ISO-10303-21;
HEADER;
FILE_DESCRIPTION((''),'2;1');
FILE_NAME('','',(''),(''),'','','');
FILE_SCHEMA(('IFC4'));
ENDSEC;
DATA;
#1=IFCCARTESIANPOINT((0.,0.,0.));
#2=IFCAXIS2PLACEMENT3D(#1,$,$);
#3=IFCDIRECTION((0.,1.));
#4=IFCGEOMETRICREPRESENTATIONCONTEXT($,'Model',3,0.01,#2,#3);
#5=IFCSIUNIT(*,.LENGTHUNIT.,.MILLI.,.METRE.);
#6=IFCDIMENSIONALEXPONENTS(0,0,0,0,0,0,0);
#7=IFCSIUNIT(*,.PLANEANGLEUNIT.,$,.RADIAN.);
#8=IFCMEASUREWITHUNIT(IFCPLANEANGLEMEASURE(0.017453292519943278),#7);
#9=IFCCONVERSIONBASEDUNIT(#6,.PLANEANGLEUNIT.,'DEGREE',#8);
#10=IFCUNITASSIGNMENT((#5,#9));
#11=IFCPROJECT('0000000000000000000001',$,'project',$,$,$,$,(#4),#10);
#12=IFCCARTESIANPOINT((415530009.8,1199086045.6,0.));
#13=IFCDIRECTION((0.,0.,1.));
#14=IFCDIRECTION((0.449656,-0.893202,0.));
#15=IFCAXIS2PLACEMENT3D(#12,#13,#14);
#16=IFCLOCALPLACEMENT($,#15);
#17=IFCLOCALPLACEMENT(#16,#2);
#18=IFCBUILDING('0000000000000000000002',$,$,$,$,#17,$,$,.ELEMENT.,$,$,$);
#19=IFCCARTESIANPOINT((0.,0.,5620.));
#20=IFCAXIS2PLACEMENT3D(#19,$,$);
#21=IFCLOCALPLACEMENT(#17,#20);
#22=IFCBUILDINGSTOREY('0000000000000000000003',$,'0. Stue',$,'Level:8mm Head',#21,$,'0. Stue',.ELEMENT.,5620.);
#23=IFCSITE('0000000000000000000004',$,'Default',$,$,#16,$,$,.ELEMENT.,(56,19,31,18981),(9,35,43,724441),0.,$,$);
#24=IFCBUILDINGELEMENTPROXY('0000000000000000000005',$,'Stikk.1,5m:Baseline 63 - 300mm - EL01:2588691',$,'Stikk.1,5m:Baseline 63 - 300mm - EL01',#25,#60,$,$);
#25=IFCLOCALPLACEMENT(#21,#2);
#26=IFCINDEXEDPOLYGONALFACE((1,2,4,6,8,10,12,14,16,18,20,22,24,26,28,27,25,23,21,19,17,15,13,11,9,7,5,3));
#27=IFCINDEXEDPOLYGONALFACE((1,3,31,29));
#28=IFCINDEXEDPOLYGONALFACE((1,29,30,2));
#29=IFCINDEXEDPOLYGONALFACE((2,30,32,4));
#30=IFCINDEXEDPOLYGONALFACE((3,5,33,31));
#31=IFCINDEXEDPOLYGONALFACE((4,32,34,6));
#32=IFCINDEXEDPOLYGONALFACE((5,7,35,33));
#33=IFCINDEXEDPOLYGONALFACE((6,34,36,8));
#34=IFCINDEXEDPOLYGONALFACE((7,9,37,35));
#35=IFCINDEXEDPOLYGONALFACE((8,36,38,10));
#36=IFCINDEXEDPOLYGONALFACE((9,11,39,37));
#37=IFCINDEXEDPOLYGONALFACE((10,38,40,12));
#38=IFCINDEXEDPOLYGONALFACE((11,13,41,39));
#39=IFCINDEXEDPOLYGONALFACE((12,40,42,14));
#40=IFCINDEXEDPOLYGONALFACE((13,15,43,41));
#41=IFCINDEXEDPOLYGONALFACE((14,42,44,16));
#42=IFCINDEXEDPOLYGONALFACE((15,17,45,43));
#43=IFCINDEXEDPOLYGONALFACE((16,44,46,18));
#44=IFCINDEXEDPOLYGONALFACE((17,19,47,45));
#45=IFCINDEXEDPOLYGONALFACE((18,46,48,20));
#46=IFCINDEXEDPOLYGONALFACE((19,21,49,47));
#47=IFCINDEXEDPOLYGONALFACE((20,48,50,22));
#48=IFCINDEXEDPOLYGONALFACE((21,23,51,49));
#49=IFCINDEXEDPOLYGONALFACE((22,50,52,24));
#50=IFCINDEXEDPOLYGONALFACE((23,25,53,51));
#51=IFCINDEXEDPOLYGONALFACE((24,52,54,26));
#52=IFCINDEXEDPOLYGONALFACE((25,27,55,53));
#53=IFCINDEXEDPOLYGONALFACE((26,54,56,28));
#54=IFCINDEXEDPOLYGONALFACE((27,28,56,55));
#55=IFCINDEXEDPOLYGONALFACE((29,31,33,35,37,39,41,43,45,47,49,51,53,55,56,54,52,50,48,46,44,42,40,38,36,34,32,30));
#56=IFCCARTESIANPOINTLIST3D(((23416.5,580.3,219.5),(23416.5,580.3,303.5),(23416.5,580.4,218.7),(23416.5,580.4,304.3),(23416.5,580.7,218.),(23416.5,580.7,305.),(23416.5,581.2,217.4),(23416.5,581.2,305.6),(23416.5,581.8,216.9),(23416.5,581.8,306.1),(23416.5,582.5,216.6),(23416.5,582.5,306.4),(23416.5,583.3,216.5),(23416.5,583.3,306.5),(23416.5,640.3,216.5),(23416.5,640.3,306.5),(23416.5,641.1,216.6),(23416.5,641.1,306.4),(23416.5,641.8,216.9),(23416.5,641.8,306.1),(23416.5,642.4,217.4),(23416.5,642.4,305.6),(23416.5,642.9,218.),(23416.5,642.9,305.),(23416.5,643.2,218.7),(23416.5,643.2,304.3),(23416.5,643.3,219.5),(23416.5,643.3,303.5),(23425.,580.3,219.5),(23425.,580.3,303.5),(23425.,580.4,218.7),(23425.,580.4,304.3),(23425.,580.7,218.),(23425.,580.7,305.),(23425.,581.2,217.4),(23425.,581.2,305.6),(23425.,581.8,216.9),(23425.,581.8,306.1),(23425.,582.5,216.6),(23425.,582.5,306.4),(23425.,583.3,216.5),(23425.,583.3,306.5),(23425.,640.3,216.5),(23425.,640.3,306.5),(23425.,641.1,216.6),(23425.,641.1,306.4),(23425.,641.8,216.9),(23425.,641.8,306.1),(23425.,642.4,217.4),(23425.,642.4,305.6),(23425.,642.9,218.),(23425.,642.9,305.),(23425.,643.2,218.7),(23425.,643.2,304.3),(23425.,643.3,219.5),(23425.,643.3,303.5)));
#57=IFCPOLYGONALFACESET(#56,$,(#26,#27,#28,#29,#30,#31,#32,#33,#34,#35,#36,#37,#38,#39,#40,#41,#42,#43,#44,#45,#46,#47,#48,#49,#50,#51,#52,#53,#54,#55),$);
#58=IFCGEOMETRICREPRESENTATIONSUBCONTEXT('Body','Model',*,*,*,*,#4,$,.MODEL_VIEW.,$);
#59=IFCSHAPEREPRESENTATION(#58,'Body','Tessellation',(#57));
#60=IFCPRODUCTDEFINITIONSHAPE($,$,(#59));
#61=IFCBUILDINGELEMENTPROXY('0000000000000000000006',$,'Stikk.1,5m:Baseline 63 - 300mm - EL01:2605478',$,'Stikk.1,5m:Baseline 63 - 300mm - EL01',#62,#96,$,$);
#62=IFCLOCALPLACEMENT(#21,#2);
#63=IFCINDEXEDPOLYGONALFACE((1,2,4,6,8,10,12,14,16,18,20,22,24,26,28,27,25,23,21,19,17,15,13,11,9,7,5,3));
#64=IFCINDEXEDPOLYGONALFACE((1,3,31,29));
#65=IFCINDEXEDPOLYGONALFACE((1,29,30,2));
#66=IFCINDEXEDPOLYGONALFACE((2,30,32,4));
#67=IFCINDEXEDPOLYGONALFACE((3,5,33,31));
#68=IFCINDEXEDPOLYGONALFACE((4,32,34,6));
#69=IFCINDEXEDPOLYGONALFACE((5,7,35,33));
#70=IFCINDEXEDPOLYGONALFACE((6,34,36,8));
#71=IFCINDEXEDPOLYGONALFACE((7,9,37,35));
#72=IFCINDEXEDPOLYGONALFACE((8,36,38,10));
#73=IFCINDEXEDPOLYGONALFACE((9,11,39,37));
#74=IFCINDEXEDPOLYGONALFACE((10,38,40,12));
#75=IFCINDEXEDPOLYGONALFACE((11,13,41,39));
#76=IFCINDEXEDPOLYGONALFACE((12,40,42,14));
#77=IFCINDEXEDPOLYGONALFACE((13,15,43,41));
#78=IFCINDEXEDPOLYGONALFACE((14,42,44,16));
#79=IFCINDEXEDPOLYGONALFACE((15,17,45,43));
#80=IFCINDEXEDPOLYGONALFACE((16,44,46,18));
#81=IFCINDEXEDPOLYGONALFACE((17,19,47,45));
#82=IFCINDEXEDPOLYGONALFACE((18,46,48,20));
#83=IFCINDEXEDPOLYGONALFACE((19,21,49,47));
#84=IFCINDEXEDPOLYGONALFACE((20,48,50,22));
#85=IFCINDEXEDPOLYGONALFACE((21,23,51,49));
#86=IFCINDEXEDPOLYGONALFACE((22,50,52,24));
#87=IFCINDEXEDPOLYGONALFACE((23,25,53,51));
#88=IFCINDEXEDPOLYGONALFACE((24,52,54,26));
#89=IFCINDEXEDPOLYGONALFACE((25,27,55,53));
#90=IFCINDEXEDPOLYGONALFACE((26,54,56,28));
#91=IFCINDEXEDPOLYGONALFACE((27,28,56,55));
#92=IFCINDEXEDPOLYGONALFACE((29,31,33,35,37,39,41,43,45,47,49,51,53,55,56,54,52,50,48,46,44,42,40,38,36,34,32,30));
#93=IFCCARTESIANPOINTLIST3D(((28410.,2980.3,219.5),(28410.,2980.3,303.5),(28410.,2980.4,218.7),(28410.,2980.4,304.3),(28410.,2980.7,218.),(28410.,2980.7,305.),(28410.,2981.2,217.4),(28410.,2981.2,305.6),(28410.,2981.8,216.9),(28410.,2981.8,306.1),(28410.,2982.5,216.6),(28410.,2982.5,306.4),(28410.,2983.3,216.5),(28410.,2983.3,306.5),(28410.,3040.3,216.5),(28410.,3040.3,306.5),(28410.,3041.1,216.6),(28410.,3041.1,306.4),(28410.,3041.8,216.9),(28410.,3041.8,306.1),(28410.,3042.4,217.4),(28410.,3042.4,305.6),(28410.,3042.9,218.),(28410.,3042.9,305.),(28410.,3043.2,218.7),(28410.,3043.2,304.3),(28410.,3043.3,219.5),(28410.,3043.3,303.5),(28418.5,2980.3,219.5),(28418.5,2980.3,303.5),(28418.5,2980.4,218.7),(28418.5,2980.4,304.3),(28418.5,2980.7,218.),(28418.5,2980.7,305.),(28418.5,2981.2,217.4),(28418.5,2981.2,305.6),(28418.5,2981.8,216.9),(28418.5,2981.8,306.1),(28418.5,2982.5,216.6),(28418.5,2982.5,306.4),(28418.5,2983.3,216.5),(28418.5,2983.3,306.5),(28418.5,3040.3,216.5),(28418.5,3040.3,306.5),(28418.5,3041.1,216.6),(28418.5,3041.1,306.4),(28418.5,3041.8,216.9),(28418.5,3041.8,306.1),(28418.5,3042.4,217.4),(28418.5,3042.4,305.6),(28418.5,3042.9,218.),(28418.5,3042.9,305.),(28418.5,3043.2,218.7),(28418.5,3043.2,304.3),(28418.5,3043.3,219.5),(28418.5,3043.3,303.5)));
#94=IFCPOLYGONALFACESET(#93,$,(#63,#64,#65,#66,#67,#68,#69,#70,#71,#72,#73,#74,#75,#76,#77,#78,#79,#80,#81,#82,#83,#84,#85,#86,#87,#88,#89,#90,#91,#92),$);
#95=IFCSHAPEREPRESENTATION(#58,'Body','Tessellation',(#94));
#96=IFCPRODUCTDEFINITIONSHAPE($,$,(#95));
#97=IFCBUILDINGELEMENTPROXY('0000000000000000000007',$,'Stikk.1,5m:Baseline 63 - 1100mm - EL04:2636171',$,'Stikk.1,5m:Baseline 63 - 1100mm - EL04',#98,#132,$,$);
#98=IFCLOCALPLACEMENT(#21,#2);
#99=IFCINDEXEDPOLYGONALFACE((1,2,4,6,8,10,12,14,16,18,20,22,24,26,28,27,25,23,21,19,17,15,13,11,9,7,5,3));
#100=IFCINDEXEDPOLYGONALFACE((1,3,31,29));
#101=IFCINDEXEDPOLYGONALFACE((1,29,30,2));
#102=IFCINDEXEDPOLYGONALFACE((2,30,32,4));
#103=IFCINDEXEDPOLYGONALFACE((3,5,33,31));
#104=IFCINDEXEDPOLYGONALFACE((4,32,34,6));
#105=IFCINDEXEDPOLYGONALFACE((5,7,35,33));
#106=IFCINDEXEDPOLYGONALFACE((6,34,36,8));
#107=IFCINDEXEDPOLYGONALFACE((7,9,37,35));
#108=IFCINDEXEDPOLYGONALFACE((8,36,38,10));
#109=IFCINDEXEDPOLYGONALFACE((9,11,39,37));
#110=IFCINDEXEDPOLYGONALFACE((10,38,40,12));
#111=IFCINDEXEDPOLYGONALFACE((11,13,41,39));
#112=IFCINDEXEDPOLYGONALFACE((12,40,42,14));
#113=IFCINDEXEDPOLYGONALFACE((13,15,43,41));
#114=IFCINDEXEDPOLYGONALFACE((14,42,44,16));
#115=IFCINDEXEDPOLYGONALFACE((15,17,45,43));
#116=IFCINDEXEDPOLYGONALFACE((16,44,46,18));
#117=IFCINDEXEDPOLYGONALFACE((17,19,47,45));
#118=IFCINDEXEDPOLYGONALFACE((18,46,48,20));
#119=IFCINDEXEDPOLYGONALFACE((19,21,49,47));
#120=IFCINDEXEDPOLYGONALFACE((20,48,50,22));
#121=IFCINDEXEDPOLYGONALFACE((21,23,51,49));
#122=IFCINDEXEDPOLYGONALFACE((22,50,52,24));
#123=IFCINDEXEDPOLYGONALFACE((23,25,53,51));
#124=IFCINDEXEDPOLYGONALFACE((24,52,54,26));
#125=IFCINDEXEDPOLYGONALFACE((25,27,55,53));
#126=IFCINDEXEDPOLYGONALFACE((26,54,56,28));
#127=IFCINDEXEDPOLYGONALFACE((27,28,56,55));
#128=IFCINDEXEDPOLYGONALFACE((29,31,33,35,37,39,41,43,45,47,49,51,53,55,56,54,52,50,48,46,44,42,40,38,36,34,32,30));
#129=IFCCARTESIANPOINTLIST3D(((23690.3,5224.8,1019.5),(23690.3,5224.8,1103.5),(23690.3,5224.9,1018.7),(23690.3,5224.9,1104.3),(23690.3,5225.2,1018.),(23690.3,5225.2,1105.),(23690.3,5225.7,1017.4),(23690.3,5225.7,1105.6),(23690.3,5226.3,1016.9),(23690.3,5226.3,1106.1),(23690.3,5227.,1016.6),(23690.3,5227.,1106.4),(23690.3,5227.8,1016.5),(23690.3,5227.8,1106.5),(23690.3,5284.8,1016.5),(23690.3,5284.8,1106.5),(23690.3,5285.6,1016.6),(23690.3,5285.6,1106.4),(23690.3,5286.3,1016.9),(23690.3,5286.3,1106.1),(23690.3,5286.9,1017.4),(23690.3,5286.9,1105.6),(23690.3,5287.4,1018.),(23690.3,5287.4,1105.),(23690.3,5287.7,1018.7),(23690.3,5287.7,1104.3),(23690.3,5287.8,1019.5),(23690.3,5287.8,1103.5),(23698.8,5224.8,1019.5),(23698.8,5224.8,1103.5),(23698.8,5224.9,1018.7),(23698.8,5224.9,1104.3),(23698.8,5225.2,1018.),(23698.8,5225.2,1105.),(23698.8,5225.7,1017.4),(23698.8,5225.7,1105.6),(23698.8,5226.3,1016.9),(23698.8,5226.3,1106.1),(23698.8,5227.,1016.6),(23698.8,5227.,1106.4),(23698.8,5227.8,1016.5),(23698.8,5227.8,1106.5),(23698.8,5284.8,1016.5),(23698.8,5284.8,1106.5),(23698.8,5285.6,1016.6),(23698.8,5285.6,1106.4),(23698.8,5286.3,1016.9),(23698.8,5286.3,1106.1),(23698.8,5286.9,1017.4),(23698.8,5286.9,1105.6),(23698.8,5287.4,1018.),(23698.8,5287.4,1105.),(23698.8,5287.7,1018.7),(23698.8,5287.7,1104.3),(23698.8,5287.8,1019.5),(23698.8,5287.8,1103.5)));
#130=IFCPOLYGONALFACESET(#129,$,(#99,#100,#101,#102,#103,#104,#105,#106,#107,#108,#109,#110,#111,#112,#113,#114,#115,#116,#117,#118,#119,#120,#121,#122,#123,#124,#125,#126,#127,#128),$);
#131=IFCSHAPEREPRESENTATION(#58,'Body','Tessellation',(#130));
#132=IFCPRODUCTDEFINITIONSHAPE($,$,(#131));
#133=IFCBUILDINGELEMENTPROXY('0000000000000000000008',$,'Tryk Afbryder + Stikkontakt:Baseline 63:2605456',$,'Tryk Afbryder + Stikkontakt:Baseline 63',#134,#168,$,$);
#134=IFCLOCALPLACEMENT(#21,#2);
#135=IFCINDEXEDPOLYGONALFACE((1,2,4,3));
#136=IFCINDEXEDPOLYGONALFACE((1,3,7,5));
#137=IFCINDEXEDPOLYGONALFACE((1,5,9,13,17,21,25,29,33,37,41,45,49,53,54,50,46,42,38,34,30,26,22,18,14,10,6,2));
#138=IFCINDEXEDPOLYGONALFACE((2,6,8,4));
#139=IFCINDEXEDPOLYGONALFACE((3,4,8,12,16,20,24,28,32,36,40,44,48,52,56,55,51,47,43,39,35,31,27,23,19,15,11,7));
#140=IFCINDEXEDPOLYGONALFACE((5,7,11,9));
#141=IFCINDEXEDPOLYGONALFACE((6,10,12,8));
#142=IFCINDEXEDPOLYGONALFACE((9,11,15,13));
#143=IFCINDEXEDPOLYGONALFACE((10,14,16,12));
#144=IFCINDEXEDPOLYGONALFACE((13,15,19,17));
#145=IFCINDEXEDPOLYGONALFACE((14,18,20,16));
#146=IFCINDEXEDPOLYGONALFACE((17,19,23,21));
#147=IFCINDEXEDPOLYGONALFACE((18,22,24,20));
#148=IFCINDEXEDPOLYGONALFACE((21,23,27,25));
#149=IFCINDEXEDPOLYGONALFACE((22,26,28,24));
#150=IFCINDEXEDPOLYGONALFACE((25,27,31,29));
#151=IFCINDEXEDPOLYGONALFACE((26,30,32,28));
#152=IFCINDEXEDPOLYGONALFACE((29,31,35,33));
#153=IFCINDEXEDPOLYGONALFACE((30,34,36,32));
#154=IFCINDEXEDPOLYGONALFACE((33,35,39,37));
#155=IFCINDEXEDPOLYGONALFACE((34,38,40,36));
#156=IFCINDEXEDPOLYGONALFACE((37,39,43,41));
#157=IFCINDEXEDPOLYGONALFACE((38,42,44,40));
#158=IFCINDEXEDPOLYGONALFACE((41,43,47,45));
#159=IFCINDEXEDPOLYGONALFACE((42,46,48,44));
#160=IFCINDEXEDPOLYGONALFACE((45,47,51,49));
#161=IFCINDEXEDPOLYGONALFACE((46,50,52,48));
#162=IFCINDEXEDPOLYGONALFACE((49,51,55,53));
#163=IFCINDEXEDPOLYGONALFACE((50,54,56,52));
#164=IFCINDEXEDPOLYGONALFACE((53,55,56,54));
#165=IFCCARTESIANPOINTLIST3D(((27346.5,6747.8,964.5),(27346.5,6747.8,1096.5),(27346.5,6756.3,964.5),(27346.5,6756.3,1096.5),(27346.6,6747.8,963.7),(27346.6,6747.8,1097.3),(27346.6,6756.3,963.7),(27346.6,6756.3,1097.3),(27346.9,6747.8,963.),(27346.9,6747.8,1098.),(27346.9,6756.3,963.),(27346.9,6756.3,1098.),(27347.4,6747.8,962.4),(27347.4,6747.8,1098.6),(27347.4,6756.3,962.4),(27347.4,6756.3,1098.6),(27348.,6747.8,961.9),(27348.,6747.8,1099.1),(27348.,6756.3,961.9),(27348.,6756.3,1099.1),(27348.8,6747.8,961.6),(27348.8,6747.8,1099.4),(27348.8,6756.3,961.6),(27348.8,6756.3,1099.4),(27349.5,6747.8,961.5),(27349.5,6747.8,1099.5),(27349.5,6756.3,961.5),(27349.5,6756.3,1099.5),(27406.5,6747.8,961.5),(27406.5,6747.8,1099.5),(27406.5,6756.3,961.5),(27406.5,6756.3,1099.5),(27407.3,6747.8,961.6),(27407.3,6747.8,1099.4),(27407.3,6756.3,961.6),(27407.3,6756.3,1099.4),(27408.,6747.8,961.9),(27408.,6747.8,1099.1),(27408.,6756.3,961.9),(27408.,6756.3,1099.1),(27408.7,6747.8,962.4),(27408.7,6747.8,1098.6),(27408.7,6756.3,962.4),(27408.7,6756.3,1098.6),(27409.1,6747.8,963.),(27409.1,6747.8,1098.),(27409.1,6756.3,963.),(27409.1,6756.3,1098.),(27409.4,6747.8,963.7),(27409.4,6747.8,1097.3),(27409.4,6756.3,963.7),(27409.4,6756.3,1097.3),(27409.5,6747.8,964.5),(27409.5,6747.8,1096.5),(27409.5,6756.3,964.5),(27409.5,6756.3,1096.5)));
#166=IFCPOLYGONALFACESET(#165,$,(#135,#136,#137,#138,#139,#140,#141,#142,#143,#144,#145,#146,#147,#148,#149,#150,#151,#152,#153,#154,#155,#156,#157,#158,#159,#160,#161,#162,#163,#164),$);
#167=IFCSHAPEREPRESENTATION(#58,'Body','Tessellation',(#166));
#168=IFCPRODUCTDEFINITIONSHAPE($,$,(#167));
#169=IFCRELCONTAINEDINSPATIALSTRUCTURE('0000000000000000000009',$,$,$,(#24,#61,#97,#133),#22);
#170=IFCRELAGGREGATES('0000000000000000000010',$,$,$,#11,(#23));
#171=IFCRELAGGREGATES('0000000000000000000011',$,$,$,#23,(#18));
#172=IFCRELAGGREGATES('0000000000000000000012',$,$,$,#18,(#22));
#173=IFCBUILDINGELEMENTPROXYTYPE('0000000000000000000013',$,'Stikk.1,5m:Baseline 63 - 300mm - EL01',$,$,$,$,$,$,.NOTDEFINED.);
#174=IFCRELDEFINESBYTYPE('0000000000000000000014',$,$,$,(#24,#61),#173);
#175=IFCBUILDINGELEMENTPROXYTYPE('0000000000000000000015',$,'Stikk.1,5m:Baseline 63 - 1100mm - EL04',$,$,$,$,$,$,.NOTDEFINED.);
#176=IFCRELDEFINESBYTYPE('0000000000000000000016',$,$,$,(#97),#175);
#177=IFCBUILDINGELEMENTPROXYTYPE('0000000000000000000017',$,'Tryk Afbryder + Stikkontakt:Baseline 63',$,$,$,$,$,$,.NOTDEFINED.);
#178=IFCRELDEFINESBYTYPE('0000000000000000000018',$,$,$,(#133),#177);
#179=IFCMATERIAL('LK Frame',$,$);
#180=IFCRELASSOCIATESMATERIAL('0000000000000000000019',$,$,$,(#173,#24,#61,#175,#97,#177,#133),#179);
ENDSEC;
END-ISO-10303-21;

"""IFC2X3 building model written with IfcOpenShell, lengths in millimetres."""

from ifc_helpers import new_model, entity, si_unit, converted_unit, direction, frame, frame_2d, origin, place, context, subcontext, project, spatial, polyline, circle_curve, parameter, trimmed, segment, composite_curve, outline, extrude, source, transform, mapped, material, type_object, type_shapes, element, save


model = new_model("IFC2X3")

# Units and contexts
model_context = context("Model", 3, precision=0.01, world=origin(), true_north=direction((0.0, 1.0)))
body_context = subcontext(model_context, "Body", "Model", "MODEL_VIEW")
ifc_project = project(units=[si_unit("LENGTHUNIT", "METRE", prefix="MILLI"), converted_unit("PLANEANGLEUNIT", "DEGREE", entity("IfcPlaneAngleMeasure", 0.017453292519943278), si_unit("PLANEANGLEUNIT", "RADIAN"), dimensions=[0, 0, 0, 0, 0, 0, 0])], contexts=[model_context])

# Site, building, storey
site_placement = place(None, frame((415530009.8, 1199086045.6, 0.0), z_axis=(0.0, 0.0, 1.0), x_axis=(0.449656, -0.893202, 0.0)))
site = spatial("IfcSite", under=ifc_project, at=site_placement, Name="Default", CompositionType="ELEMENT", RefLatitude=(56, 19, 31, 18981), RefLongitude=(9, 35, 43, 724441), RefElevation=0.0)
building_placement = place(site_placement, origin())
building = spatial("IfcBuilding", under=site, at=building_placement, CompositionType="ELEMENT")
storey_placement = place(building_placement, frame((0.0, 0.0, 5620.0)))
storey = spatial("IfcBuildingStorey", under=building, at=storey_placement, Name="0. Stue", ObjectType="Level:8mm Head", LongName="0. Stue", CompositionType="ELEMENT", Elevation=5620.0)

# Building element proxies
ifc_material_1 = material(Name="LK Frame")
building_element_proxy_type_1 = type_object("IfcBuildingElementProxyType", Name="Stikk.1,5m:Baseline 63 - 300mm - EL01", PredefinedType="NOTDEFINED", material=ifc_material_1)
shared_shape_1 = source(origin(), body_context, "Body", "SweptSolid", [
    extrude(outline(composite_curve([segment(polyline([(-42.0, -31.5), (42.0, -31.5)]), True, "CONTINUOUS"), segment(trimmed(circle_curve(frame_2d((42.0, -28.5), x_axis=(-1.0, 0.0)), 3.0), [parameter(90.0)], [parameter(180.0)], True, "PARAMETER"), True, "CONTINUOUS"), segment(polyline([(45.0, -28.5), (45.0, 28.5)]), True, "CONTINUOUS"), segment(trimmed(circle_curve(frame_2d((42.0, 28.5), x_axis=(-1.0, 0.0)), 3.0), [parameter(180.0)], [parameter(270.0)], True, "PARAMETER"), True, "CONTINUOUS"), segment(polyline([(42.0, 31.5), (-42.0, 31.5)]), True, "CONTINUOUS"), segment(trimmed(circle_curve(frame_2d((-42.0, 28.5), x_axis=(1.0, 0.0)), 3.0), [parameter(90.0)], [parameter(180.0)], True, "PARAMETER"), True, "CONTINUOUS"), segment(polyline([(-45.0, 28.5), (-45.0, -28.5)]), True, "CONTINUOUS"), segment(trimmed(circle_curve(frame_2d((-42.0, -28.5), x_axis=(1.0, 0.0)), 3.0), [parameter(180.0)], [parameter(270.0)], True, "PARAMETER"), True, "CONTINUOUS")], self_intersect=False)), frame((0.0, -38.5, 0.0), z_axis=(0.0, 0.0, 1.0), x_axis=(0.0, 1.0, 0.0)), (0.0, 0.0, 1.0), 8.5),
])
type_shapes(building_element_proxy_type_1, [shared_shape_1])
for number, where, z_axis, x_axis, name in (
    (1, (23425.0, 611.8, 300.0), (-1.0, 0.0, 0.0), (0.0, -1.0, 0.0), "Stikk.1,5m:Baseline 63 - 300mm - EL01:2588691"),
    (2, (28410.0, 3011.8, 300.0), (1.0, 0.0, 0.0), (0.0, 1.0, 0.0), "Stikk.1,5m:Baseline 63 - 300mm - EL01:2605478"),
):
    element("IfcBuildingElementProxy", number, at=place(storey_placement, frame(where, z_axis=z_axis, x_axis=x_axis)), inside=storey, type_object=building_element_proxy_type_1, material=ifc_material_1, Name=name, ObjectType="Stikk.1,5m:Baseline 63 - 300mm - EL01", context=body_context, shape_type="MappedRepresentation", body=[
        mapped(shared_shape_1, transform((0.0, 0.0, 0.0), scale=1.0)),
    ])
building_element_proxy_type_2 = type_object("IfcBuildingElementProxyType", Name="Stikk.1,5m:Baseline 63 - 1100mm - EL04", PredefinedType="NOTDEFINED", material=ifc_material_1)
shared_shape_2 = source(origin(), body_context, "Body", "SweptSolid", [
    extrude(outline(composite_curve([segment(polyline([(-42.0, -31.5), (42.0, -31.5)]), True, "CONTINUOUS"), segment(trimmed(circle_curve(frame_2d((42.0, -28.5), x_axis=(-1.0, 0.0)), 3.0), [parameter(90.0)], [parameter(180.0)], True, "PARAMETER"), True, "CONTINUOUS"), segment(polyline([(45.0, -28.5), (45.0, 28.5)]), True, "CONTINUOUS"), segment(trimmed(circle_curve(frame_2d((42.0, 28.5), x_axis=(-1.0, 0.0)), 3.0), [parameter(180.0)], [parameter(270.0)], True, "PARAMETER"), True, "CONTINUOUS"), segment(polyline([(42.0, 31.5), (-42.0, 31.5)]), True, "CONTINUOUS"), segment(trimmed(circle_curve(frame_2d((-42.0, 28.5), x_axis=(1.0, 0.0)), 3.0), [parameter(90.0)], [parameter(180.0)], True, "PARAMETER"), True, "CONTINUOUS"), segment(polyline([(-45.0, 28.5), (-45.0, -28.5)]), True, "CONTINUOUS"), segment(trimmed(circle_curve(frame_2d((-42.0, -28.5), x_axis=(1.0, 0.0)), 3.0), [parameter(180.0)], [parameter(270.0)], True, "PARAMETER"), True, "CONTINUOUS")], self_intersect=False)), frame((0.0, -38.5, 0.0), z_axis=(0.0, 0.0, 1.0), x_axis=(0.0, 1.0, 0.0)), (0.0, 0.0, 1.0), 8.5),
])
type_shapes(building_element_proxy_type_2, [shared_shape_2])
proxy_1_placement = place(storey_placement, frame((23690.3, 5256.3, 1100.0), z_axis=(1.0, 0.0, 0.0), x_axis=(0.0, 1.0, 0.0)))
element("IfcBuildingElementProxy", 3, at=proxy_1_placement, inside=storey, type_object=building_element_proxy_type_2, material=ifc_material_1, Name="Stikk.1,5m:Baseline 63 - 1100mm - EL04:2636171", ObjectType="Stikk.1,5m:Baseline 63 - 1100mm - EL04", context=body_context, shape_type="MappedRepresentation", body=[
    mapped(shared_shape_2, transform((0.0, 0.0, 0.0), scale=1.0)),
])
building_element_proxy_type_3 = type_object("IfcBuildingElementProxyType", Name="Tryk Afbryder + Stikkontakt:Baseline 63", PredefinedType="NOTDEFINED", material=ifc_material_1)
shared_shape_3 = source(origin(), body_context, "Body", "SweptSolid", [
    extrude(outline(composite_curve([segment(polyline([(-66.0, -31.5), (66.0, -31.5)]), True, "CONTINUOUS"), segment(trimmed(circle_curve(frame_2d((66.0, -28.5), x_axis=(-1.0, 0.0)), 3.0), [parameter(90.0)], [parameter(180.0)], True, "PARAMETER"), True, "CONTINUOUS"), segment(polyline([(69.0, -28.5), (69.0, 28.5)]), True, "CONTINUOUS"), segment(trimmed(circle_curve(frame_2d((66.0, 28.5), x_axis=(-1.0, 0.0)), 3.0), [parameter(180.0)], [parameter(270.0)], True, "PARAMETER"), True, "CONTINUOUS"), segment(polyline([(66.0, 31.5), (-66.0, 31.5)]), True, "CONTINUOUS"), segment(trimmed(circle_curve(frame_2d((-66.0, 28.5), x_axis=(1.0, 0.0)), 3.0), [parameter(90.0)], [parameter(180.0)], True, "PARAMETER"), True, "CONTINUOUS"), segment(polyline([(-69.0, 28.5), (-69.0, -28.5)]), True, "CONTINUOUS"), segment(trimmed(circle_curve(frame_2d((-66.0, -28.5), x_axis=(1.0, 0.0)), 3.0), [parameter(180.0)], [parameter(270.0)], True, "PARAMETER"), True, "CONTINUOUS")], self_intersect=False)), frame((0.0, -69.5, 0.0), z_axis=(0.0, 0.0, 1.0), x_axis=(0.0, 1.0, 0.0)), (0.0, 0.0, 1.0), 8.5),
])
type_shapes(building_element_proxy_type_3, [shared_shape_3])
proxy_2_placement = place(storey_placement, frame((27378.0, 6756.3, 1100.0), z_axis=(0.0, -1.0, 0.0), x_axis=(1.0, 0.0, 0.0)))
element("IfcBuildingElementProxy", 4, at=proxy_2_placement, inside=storey, type_object=building_element_proxy_type_3, material=ifc_material_1, Name="Tryk Afbryder + Stikkontakt:Baseline 63:2605456", ObjectType="Tryk Afbryder + Stikkontakt:Baseline 63", context=body_context, shape_type="MappedRepresentation", body=[
    mapped(shared_shape_3, transform((0.0, 0.0, 0.0), scale=1.0)),
])

save(model, "model.ifc")
